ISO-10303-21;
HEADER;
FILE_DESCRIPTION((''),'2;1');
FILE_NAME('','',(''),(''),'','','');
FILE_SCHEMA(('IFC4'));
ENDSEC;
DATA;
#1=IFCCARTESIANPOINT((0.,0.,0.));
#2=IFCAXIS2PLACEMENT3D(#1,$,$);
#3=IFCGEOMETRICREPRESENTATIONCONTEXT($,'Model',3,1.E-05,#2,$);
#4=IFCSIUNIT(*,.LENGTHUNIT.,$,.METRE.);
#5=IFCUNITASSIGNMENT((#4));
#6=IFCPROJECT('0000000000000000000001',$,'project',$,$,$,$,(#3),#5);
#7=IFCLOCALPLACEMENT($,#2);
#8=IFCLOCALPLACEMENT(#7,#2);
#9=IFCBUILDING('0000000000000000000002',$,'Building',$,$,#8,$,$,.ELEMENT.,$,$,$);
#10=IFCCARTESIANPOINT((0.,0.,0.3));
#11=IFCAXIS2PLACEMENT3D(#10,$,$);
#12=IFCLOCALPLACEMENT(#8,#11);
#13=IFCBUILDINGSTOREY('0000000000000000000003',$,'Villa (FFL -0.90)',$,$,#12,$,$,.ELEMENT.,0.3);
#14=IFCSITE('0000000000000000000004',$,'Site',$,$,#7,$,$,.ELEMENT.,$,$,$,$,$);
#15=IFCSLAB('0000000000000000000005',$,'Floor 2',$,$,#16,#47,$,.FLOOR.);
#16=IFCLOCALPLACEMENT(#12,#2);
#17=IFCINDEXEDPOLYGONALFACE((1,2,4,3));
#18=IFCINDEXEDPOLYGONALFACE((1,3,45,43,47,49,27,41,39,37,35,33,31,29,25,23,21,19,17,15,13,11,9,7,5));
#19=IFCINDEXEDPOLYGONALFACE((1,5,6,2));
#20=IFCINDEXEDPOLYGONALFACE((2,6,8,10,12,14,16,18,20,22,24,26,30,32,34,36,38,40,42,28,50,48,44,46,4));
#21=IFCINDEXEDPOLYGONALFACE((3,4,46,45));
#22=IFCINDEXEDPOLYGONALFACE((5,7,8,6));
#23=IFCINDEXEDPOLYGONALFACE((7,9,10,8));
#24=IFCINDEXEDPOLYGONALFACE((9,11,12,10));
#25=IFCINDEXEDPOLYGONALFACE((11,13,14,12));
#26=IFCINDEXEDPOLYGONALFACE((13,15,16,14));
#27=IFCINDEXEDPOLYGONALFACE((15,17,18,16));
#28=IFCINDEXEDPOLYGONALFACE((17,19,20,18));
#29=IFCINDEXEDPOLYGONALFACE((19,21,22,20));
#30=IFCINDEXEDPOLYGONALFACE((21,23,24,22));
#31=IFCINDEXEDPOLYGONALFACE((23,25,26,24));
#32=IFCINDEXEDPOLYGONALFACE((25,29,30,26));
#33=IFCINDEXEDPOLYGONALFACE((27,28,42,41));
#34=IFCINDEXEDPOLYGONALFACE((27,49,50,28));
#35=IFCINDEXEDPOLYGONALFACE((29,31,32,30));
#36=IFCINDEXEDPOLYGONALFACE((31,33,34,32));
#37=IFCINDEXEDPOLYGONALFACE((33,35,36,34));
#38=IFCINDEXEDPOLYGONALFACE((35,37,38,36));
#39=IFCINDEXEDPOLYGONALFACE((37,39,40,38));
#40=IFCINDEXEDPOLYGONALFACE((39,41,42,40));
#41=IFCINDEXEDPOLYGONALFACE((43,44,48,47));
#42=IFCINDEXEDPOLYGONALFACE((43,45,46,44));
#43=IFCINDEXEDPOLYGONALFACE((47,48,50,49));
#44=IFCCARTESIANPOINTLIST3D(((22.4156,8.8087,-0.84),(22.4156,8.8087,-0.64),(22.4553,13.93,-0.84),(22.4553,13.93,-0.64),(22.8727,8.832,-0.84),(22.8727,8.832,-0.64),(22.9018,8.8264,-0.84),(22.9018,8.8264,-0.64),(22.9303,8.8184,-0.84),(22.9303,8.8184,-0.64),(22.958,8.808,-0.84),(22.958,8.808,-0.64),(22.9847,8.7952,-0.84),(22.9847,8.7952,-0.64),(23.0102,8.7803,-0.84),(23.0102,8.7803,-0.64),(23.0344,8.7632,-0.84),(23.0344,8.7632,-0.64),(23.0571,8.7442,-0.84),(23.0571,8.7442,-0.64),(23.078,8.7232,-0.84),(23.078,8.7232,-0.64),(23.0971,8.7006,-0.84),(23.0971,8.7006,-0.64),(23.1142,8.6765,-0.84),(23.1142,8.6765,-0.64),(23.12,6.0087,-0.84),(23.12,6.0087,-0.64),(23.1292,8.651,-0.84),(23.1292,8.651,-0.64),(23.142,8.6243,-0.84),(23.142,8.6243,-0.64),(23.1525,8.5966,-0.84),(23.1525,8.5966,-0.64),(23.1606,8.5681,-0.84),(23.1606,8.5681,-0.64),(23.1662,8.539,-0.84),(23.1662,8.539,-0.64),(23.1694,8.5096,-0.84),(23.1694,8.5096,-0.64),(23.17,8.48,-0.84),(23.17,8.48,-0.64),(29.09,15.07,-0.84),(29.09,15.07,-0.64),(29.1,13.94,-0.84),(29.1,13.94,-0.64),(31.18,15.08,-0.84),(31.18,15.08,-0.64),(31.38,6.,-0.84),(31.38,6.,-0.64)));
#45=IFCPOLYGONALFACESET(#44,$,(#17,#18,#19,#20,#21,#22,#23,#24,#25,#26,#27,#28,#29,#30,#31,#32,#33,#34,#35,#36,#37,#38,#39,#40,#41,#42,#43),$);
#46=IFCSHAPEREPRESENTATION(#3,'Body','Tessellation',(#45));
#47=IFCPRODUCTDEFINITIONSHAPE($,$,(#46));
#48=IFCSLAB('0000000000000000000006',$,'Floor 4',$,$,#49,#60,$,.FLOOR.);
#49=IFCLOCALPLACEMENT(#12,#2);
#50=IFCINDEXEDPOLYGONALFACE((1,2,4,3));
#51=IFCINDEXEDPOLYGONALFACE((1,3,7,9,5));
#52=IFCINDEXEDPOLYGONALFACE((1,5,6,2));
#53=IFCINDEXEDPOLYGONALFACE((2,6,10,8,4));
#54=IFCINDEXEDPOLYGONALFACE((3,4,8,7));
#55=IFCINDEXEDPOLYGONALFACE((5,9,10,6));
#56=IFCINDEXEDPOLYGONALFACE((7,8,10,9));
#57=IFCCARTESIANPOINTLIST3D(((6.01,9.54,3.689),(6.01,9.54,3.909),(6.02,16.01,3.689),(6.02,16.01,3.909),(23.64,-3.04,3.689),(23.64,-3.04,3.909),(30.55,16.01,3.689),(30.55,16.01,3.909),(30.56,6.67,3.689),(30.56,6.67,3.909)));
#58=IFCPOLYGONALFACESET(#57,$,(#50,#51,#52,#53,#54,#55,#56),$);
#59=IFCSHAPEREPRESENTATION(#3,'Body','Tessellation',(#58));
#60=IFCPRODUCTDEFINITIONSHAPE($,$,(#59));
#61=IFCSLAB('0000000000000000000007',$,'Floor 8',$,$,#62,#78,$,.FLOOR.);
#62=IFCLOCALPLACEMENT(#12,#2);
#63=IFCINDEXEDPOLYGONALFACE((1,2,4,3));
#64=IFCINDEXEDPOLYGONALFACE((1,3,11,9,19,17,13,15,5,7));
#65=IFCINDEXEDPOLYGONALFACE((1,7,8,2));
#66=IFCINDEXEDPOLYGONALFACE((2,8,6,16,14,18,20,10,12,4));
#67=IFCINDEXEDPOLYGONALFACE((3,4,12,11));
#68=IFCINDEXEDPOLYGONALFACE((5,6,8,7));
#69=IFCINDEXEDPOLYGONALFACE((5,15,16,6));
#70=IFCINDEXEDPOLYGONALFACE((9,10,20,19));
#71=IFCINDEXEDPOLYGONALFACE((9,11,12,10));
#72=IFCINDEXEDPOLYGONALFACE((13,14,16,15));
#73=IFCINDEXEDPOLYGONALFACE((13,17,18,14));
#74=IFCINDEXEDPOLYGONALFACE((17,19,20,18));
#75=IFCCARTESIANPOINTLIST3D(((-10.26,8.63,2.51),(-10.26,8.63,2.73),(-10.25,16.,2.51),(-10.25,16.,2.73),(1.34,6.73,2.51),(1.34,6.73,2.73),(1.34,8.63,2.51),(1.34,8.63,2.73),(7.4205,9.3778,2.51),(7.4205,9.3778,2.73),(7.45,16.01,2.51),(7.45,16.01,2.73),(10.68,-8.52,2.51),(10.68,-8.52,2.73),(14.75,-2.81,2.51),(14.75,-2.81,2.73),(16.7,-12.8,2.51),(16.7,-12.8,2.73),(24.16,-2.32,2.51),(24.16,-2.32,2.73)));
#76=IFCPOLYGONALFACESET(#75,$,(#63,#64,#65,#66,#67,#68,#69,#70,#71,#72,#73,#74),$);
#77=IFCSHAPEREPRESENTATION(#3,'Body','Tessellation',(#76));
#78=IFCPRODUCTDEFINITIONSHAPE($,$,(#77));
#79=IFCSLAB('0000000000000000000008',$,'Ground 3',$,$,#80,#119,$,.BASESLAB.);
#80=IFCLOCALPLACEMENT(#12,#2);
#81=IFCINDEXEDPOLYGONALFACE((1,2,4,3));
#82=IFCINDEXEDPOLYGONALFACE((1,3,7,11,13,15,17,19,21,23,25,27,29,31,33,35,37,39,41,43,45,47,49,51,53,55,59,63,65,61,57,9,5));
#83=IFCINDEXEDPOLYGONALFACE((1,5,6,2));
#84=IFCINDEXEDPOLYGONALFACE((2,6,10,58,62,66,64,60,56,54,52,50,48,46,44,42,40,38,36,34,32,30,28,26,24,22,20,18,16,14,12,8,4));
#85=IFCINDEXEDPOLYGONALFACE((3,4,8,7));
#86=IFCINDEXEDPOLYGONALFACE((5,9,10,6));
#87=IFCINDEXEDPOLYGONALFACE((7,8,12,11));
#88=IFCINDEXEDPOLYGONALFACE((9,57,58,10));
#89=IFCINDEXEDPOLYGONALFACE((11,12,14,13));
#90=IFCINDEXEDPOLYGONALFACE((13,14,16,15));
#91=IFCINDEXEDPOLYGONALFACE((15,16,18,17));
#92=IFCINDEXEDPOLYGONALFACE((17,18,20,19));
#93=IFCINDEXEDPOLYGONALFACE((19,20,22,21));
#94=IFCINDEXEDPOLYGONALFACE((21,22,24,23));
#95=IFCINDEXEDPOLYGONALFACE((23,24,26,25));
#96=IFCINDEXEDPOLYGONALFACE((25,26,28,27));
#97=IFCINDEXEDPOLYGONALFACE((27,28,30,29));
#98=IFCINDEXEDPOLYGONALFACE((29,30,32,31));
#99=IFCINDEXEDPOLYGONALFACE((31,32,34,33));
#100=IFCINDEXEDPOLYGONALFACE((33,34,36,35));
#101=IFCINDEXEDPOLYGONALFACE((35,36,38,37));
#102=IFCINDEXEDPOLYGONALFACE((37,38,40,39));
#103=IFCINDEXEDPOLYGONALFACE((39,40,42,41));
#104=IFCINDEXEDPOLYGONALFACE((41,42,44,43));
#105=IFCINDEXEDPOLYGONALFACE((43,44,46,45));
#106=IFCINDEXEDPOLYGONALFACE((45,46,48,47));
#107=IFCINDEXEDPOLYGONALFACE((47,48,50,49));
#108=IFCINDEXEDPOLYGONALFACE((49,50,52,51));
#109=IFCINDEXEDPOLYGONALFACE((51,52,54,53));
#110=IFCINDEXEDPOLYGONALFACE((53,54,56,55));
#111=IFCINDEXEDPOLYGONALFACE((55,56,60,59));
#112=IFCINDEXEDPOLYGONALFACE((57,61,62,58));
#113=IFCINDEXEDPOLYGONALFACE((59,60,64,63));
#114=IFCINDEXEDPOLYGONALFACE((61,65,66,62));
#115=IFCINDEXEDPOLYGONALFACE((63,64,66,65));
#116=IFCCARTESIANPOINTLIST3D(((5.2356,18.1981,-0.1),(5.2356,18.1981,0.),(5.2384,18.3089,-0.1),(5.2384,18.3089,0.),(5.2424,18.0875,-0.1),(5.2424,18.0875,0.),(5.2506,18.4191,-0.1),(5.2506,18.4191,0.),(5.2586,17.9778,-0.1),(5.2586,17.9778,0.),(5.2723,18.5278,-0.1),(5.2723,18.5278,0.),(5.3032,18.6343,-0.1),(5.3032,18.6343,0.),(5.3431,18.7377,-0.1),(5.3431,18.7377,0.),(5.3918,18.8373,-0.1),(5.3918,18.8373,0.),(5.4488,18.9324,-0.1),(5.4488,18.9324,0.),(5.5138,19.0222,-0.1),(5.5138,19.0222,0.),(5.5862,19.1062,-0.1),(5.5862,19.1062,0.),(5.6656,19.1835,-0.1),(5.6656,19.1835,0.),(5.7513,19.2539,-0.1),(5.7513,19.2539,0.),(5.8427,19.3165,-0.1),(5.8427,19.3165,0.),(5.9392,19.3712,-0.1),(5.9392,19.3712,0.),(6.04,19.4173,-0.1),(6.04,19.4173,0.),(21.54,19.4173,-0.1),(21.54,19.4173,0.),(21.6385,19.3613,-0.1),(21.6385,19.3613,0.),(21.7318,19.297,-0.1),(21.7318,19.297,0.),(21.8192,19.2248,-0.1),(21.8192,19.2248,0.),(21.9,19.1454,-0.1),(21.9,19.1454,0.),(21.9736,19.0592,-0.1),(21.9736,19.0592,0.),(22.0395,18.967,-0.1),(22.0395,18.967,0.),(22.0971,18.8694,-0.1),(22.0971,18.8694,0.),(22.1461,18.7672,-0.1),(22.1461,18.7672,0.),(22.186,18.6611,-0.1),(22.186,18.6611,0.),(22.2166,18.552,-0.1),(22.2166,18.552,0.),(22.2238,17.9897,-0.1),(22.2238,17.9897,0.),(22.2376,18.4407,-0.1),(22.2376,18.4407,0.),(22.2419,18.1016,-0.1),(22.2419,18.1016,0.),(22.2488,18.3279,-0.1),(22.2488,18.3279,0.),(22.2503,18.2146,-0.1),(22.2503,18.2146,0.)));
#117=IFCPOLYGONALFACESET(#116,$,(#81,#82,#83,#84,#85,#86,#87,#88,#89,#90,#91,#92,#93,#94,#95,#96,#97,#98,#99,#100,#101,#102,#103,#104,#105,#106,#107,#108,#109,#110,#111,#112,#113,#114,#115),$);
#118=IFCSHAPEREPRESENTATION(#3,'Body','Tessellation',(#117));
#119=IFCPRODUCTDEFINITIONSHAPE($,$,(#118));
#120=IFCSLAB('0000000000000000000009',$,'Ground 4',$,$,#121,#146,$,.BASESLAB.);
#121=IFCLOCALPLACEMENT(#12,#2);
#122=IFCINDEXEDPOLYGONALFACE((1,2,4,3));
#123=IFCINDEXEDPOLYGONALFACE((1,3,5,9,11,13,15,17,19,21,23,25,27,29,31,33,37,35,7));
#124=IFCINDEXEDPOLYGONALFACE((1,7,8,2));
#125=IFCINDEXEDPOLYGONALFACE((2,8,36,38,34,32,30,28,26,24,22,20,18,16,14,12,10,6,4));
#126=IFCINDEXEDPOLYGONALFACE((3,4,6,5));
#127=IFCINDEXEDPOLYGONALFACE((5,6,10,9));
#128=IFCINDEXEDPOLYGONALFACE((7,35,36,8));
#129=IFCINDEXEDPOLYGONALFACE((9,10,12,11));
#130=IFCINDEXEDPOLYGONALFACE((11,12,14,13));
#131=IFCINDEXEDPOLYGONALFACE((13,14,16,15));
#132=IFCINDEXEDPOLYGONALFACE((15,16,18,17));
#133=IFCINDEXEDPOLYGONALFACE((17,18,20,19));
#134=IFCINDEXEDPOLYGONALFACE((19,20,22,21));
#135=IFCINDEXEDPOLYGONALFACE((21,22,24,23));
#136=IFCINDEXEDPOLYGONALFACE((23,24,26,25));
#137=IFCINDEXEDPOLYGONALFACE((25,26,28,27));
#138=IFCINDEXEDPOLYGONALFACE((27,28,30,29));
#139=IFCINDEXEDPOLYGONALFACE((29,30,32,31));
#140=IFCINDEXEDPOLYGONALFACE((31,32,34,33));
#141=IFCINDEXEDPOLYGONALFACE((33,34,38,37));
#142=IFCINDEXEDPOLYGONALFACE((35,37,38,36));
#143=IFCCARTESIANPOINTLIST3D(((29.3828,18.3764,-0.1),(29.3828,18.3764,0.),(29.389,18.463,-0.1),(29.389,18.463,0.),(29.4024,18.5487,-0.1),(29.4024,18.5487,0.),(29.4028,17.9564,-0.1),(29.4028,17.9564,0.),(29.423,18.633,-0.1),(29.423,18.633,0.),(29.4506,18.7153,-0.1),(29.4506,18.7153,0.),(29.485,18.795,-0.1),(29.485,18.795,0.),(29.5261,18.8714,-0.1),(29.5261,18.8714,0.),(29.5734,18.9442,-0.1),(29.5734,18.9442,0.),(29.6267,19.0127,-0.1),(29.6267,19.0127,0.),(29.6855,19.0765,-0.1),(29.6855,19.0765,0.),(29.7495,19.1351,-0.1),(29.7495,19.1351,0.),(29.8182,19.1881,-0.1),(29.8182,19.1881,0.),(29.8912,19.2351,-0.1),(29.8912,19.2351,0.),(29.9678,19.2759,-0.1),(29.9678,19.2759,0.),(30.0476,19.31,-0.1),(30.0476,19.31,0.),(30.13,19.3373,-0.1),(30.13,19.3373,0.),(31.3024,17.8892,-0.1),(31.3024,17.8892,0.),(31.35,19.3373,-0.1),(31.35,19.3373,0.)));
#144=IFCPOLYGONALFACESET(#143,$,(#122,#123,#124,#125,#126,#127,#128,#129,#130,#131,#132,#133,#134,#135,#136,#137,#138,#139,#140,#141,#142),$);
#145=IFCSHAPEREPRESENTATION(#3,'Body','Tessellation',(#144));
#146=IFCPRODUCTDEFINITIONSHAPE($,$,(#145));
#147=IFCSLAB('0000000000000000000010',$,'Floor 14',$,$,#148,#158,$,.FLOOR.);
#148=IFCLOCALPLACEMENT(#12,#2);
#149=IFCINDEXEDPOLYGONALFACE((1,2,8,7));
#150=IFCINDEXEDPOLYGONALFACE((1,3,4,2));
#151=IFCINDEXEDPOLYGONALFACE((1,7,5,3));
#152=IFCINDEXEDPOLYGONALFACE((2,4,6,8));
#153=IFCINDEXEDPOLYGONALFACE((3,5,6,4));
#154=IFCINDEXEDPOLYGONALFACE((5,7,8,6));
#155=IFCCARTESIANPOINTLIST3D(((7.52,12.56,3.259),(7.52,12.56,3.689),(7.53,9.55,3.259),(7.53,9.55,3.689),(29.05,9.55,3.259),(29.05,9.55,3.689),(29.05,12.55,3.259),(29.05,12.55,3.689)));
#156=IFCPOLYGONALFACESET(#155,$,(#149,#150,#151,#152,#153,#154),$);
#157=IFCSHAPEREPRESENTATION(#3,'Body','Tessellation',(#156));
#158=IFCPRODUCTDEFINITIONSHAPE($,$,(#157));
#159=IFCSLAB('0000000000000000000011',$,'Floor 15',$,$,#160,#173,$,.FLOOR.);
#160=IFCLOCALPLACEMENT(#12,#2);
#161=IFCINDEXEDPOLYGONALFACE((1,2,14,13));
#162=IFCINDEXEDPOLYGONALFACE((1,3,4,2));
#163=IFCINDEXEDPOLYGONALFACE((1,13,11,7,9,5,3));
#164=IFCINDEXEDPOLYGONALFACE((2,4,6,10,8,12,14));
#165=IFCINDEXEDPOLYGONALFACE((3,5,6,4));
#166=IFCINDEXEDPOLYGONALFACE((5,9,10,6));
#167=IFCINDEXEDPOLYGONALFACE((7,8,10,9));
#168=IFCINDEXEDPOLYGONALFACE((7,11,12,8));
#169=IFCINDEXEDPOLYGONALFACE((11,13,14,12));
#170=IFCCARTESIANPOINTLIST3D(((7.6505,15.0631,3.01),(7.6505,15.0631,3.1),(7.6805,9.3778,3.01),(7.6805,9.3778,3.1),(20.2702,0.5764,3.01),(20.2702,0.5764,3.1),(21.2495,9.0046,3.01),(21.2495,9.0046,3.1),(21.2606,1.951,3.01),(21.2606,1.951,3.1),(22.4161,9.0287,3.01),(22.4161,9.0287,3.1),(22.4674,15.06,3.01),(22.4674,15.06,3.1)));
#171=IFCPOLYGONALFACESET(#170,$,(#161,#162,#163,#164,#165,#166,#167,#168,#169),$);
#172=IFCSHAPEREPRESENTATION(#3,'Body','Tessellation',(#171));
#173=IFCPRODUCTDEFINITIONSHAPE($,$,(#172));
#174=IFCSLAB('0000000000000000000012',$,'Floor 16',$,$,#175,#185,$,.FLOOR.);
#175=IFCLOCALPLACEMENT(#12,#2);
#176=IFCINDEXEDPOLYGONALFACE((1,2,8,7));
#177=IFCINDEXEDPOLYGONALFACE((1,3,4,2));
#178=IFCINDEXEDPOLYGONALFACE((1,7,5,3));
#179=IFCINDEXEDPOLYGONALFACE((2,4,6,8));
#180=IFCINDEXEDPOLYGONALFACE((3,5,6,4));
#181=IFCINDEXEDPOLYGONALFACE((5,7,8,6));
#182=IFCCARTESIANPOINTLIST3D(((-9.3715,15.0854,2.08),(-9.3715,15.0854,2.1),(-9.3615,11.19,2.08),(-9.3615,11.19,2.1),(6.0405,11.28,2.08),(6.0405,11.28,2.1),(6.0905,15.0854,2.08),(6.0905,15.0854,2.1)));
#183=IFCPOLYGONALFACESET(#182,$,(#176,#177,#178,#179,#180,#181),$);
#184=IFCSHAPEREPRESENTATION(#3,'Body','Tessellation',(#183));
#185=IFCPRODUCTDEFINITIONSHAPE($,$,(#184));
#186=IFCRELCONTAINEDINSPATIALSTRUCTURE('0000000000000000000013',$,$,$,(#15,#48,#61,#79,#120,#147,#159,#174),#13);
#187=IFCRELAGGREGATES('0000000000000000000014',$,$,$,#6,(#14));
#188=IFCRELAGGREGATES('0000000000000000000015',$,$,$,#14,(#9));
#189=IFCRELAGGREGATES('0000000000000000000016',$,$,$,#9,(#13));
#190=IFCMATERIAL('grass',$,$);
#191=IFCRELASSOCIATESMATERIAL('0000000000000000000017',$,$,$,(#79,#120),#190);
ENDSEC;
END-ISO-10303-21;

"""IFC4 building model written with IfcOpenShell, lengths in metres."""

from ifc_helpers import new_model, si_unit, frame, origin, place, context, project, spatial, polyline, outline, extrude, material, element, save


model = new_model("IFC4")

# Units and contexts
model_context = context("Model", 3, precision=1e-05, world=origin())
ifc_project = project(units=[si_unit("LENGTHUNIT", "METRE")], contexts=[model_context])

# Site, building, storey
site_placement = place(None, origin())
site = spatial("IfcSite", under=ifc_project, at=site_placement, Name="Site", CompositionType="ELEMENT")
building_placement = place(site_placement, origin())
building = spatial("IfcBuilding", under=site, at=building_placement, Name="Building", CompositionType="ELEMENT")
storey_placement = place(building_placement, frame((0.0, 0.0, 0.3)))
storey = spatial("IfcBuildingStorey", under=building, at=storey_placement, Name="Villa (FFL -0.90)", CompositionType="ELEMENT", Elevation=0.3)

# Slabs
slab_1_placement = place(storey_placement, frame((0.0, 0.0, -0.84), z_axis=(0.0, 0.0, 1.0), x_axis=(1.0, 0.0, 0.0)))
element("IfcSlab", 1, at=slab_1_placement, inside=storey, Name="Floor 2", PredefinedType="FLOOR", context=model_context, shape_type="SweptSolid", body=[
    extrude(outline(polyline([(22.4553, 13.93), (29.1, 13.94), (29.09, 15.07), (31.18, 15.08), (31.38, 6.0), (23.12, 6.0087), (23.17, 8.48), (23.1694, 8.5096), (23.1662, 8.539), (23.1606, 8.5681), (23.1525, 8.5966), (23.142, 8.6243), (23.1292, 8.651), (23.1142, 8.6765), (23.0971, 8.7006), (23.078, 8.7232), (23.0571, 8.7442), (23.0344, 8.7632), (23.0102, 8.7803), (22.9847, 8.7952), (22.958, 8.808), (22.9303, 8.8184), (22.9018, 8.8264), (22.8727, 8.832), (22.4156, 8.8087), (22.4553, 13.93)])), origin(), (0.0, 0.0, 1.0), 0.2),
])
slab_2_placement = place(storey_placement, frame((0.0, 0.0, 3.689), z_axis=(0.0, 0.0, 1.0), x_axis=(1.0, 0.0, 0.0)))
element("IfcSlab", 2, at=slab_2_placement, inside=storey, Name="Floor 4", PredefinedType="FLOOR", context=model_context, shape_type="SweptSolid", body=[
    extrude(outline(polyline([(6.02, 16.01), (6.01, 9.54), (23.64, -3.04), (30.56, 6.67), (30.55, 16.01), (6.02, 16.01)])), origin(), (0.0, 0.0, 1.0), 0.22),
])
slab_3_placement = place(storey_placement, frame((0.0, 0.0, 2.51), z_axis=(0.0, 0.0, 1.0), x_axis=(1.0, 0.0, 0.0)))
element("IfcSlab", 3, at=slab_3_placement, inside=storey, Name="Floor 8", PredefinedType="FLOOR", context=model_context, shape_type="SweptSolid", body=[
    extrude(outline(polyline([(7.45, 16.01), (-10.25, 16.0), (-10.26, 8.63), (1.34, 8.63), (1.34, 6.73), (14.75, -2.81), (10.68, -8.52), (16.7, -12.8), (24.16, -2.32), (7.4205, 9.3778), (7.45, 16.01)])), origin(), (0.0, 0.0, 1.0), 0.22),
])
ifc_material_1 = material(Name="grass")
slab_4_placement = place(storey_placement, frame((0.0, 0.0, -0.1), z_axis=(0.0, 0.0, 1.0), x_axis=(1.0, 0.0, 0.0)))
element("IfcSlab", 4, at=slab_4_placement, inside=storey, material=ifc_material_1, Name="Ground 3", PredefinedType="BASESLAB", context=model_context, shape_type="SweptSolid", body=[
    extrude(outline(polyline([(6.04, 19.4173), (21.54, 19.4173), (21.6385, 19.3613), (21.7318, 19.297), (21.8192, 19.2248), (21.9, 19.1454), (21.9736, 19.0592), (22.0395, 18.967), (22.0971, 18.8694), (22.1461, 18.7672), (22.186, 18.6611), (22.2166, 18.552), (22.2376, 18.4407), (22.2488, 18.3279), (22.2503, 18.2146), (22.2419, 18.1016), (22.2238, 17.9897), (5.2586, 17.9778), (5.2424, 18.0875), (5.2356, 18.1981), (5.2384, 18.3089), (5.2506, 18.4191), (5.2723, 18.5278), (5.3032, 18.6343), (5.3431, 18.7377), (5.3918, 18.8373), (5.4488, 18.9324), (5.5138, 19.0222), (5.5862, 19.1061), (5.6656, 19.1835), (5.7513, 19.2539), (5.8427, 19.3165), (5.9392, 19.3712), (6.04, 19.4173)])), origin(), (0.0, 0.0, 1.0), 0.1),
])
slab_5_placement = place(storey_placement, frame((0.0, 0.0, -0.1), z_axis=(0.0, 0.0, 1.0), x_axis=(1.0, 0.0, 0.0)))
element("IfcSlab", 5, at=slab_5_placement, inside=storey, material=ifc_material_1, Name="Ground 4", PredefinedType="BASESLAB", context=model_context, shape_type="SweptSolid", body=[
    extrude(outline(polyline([(30.13, 19.3373), (31.35, 19.3373), (31.3024, 17.8892), (29.4028, 17.9564), (29.3828, 18.3764), (29.389, 18.463), (29.4024, 18.5487), (29.423, 18.633), (29.4506, 18.7153), (29.485, 18.795), (29.5261, 18.8714), (29.5734, 18.9442), (29.6267, 19.0127), (29.6855, 19.0765), (29.7495, 19.1351), (29.8182, 19.1881), (29.8912, 19.2351), (29.9678, 19.2759), (30.0476, 19.31), (30.13, 19.3373)])), origin(), (0.0, 0.0, 1.0), 0.1),
])
slab_6_placement = place(storey_placement, frame((0.0, 0.0, 3.259), z_axis=(0.0, 0.0, 1.0), x_axis=(1.0, 0.0, 0.0)))
element("IfcSlab", 6, at=slab_6_placement, inside=storey, Name="Floor 14", PredefinedType="FLOOR", context=model_context, shape_type="SweptSolid", body=[
    extrude(outline(polyline([(29.05, 12.55), (7.52, 12.56), (7.53, 9.55), (29.05, 9.55), (29.05, 12.55)])), origin(), (0.0, 0.0, 1.0), 0.43),
])
slab_7_placement = place(storey_placement, frame((0.0, 0.0, 3.01), z_axis=(0.0, 0.0, 1.0), x_axis=(1.0, 0.0, 0.0)))
element("IfcSlab", 7, at=slab_7_placement, inside=storey, Name="Floor 15", PredefinedType="FLOOR", context=model_context, shape_type="SweptSolid", body=[
    extrude(outline(polyline([(22.4674, 15.06), (7.6505, 15.0631), (7.6805, 9.3778), (20.2702, 0.5764), (21.2606, 1.951), (21.2495, 9.0046), (22.4161, 9.0287), (22.4674, 15.06)])), origin(), (0.0, 0.0, 1.0), 0.09),
])
slab_8_placement = place(storey_placement, frame((0.0, 0.0, 2.08), z_axis=(0.0, 0.0, 1.0), x_axis=(1.0, 0.0, 0.0)))
element("IfcSlab", 8, at=slab_8_placement, inside=storey, Name="Floor 16", PredefinedType="FLOOR", context=model_context, shape_type="SweptSolid", body=[
    extrude(outline(polyline([(6.0905, 15.0854), (-9.3715, 15.0854), (-9.3615, 11.19), (6.0405, 11.28), (6.0905, 15.0854)])), origin(), (0.0, 0.0, 1.0), 0.02),
])

save(model, "model.ifc")
